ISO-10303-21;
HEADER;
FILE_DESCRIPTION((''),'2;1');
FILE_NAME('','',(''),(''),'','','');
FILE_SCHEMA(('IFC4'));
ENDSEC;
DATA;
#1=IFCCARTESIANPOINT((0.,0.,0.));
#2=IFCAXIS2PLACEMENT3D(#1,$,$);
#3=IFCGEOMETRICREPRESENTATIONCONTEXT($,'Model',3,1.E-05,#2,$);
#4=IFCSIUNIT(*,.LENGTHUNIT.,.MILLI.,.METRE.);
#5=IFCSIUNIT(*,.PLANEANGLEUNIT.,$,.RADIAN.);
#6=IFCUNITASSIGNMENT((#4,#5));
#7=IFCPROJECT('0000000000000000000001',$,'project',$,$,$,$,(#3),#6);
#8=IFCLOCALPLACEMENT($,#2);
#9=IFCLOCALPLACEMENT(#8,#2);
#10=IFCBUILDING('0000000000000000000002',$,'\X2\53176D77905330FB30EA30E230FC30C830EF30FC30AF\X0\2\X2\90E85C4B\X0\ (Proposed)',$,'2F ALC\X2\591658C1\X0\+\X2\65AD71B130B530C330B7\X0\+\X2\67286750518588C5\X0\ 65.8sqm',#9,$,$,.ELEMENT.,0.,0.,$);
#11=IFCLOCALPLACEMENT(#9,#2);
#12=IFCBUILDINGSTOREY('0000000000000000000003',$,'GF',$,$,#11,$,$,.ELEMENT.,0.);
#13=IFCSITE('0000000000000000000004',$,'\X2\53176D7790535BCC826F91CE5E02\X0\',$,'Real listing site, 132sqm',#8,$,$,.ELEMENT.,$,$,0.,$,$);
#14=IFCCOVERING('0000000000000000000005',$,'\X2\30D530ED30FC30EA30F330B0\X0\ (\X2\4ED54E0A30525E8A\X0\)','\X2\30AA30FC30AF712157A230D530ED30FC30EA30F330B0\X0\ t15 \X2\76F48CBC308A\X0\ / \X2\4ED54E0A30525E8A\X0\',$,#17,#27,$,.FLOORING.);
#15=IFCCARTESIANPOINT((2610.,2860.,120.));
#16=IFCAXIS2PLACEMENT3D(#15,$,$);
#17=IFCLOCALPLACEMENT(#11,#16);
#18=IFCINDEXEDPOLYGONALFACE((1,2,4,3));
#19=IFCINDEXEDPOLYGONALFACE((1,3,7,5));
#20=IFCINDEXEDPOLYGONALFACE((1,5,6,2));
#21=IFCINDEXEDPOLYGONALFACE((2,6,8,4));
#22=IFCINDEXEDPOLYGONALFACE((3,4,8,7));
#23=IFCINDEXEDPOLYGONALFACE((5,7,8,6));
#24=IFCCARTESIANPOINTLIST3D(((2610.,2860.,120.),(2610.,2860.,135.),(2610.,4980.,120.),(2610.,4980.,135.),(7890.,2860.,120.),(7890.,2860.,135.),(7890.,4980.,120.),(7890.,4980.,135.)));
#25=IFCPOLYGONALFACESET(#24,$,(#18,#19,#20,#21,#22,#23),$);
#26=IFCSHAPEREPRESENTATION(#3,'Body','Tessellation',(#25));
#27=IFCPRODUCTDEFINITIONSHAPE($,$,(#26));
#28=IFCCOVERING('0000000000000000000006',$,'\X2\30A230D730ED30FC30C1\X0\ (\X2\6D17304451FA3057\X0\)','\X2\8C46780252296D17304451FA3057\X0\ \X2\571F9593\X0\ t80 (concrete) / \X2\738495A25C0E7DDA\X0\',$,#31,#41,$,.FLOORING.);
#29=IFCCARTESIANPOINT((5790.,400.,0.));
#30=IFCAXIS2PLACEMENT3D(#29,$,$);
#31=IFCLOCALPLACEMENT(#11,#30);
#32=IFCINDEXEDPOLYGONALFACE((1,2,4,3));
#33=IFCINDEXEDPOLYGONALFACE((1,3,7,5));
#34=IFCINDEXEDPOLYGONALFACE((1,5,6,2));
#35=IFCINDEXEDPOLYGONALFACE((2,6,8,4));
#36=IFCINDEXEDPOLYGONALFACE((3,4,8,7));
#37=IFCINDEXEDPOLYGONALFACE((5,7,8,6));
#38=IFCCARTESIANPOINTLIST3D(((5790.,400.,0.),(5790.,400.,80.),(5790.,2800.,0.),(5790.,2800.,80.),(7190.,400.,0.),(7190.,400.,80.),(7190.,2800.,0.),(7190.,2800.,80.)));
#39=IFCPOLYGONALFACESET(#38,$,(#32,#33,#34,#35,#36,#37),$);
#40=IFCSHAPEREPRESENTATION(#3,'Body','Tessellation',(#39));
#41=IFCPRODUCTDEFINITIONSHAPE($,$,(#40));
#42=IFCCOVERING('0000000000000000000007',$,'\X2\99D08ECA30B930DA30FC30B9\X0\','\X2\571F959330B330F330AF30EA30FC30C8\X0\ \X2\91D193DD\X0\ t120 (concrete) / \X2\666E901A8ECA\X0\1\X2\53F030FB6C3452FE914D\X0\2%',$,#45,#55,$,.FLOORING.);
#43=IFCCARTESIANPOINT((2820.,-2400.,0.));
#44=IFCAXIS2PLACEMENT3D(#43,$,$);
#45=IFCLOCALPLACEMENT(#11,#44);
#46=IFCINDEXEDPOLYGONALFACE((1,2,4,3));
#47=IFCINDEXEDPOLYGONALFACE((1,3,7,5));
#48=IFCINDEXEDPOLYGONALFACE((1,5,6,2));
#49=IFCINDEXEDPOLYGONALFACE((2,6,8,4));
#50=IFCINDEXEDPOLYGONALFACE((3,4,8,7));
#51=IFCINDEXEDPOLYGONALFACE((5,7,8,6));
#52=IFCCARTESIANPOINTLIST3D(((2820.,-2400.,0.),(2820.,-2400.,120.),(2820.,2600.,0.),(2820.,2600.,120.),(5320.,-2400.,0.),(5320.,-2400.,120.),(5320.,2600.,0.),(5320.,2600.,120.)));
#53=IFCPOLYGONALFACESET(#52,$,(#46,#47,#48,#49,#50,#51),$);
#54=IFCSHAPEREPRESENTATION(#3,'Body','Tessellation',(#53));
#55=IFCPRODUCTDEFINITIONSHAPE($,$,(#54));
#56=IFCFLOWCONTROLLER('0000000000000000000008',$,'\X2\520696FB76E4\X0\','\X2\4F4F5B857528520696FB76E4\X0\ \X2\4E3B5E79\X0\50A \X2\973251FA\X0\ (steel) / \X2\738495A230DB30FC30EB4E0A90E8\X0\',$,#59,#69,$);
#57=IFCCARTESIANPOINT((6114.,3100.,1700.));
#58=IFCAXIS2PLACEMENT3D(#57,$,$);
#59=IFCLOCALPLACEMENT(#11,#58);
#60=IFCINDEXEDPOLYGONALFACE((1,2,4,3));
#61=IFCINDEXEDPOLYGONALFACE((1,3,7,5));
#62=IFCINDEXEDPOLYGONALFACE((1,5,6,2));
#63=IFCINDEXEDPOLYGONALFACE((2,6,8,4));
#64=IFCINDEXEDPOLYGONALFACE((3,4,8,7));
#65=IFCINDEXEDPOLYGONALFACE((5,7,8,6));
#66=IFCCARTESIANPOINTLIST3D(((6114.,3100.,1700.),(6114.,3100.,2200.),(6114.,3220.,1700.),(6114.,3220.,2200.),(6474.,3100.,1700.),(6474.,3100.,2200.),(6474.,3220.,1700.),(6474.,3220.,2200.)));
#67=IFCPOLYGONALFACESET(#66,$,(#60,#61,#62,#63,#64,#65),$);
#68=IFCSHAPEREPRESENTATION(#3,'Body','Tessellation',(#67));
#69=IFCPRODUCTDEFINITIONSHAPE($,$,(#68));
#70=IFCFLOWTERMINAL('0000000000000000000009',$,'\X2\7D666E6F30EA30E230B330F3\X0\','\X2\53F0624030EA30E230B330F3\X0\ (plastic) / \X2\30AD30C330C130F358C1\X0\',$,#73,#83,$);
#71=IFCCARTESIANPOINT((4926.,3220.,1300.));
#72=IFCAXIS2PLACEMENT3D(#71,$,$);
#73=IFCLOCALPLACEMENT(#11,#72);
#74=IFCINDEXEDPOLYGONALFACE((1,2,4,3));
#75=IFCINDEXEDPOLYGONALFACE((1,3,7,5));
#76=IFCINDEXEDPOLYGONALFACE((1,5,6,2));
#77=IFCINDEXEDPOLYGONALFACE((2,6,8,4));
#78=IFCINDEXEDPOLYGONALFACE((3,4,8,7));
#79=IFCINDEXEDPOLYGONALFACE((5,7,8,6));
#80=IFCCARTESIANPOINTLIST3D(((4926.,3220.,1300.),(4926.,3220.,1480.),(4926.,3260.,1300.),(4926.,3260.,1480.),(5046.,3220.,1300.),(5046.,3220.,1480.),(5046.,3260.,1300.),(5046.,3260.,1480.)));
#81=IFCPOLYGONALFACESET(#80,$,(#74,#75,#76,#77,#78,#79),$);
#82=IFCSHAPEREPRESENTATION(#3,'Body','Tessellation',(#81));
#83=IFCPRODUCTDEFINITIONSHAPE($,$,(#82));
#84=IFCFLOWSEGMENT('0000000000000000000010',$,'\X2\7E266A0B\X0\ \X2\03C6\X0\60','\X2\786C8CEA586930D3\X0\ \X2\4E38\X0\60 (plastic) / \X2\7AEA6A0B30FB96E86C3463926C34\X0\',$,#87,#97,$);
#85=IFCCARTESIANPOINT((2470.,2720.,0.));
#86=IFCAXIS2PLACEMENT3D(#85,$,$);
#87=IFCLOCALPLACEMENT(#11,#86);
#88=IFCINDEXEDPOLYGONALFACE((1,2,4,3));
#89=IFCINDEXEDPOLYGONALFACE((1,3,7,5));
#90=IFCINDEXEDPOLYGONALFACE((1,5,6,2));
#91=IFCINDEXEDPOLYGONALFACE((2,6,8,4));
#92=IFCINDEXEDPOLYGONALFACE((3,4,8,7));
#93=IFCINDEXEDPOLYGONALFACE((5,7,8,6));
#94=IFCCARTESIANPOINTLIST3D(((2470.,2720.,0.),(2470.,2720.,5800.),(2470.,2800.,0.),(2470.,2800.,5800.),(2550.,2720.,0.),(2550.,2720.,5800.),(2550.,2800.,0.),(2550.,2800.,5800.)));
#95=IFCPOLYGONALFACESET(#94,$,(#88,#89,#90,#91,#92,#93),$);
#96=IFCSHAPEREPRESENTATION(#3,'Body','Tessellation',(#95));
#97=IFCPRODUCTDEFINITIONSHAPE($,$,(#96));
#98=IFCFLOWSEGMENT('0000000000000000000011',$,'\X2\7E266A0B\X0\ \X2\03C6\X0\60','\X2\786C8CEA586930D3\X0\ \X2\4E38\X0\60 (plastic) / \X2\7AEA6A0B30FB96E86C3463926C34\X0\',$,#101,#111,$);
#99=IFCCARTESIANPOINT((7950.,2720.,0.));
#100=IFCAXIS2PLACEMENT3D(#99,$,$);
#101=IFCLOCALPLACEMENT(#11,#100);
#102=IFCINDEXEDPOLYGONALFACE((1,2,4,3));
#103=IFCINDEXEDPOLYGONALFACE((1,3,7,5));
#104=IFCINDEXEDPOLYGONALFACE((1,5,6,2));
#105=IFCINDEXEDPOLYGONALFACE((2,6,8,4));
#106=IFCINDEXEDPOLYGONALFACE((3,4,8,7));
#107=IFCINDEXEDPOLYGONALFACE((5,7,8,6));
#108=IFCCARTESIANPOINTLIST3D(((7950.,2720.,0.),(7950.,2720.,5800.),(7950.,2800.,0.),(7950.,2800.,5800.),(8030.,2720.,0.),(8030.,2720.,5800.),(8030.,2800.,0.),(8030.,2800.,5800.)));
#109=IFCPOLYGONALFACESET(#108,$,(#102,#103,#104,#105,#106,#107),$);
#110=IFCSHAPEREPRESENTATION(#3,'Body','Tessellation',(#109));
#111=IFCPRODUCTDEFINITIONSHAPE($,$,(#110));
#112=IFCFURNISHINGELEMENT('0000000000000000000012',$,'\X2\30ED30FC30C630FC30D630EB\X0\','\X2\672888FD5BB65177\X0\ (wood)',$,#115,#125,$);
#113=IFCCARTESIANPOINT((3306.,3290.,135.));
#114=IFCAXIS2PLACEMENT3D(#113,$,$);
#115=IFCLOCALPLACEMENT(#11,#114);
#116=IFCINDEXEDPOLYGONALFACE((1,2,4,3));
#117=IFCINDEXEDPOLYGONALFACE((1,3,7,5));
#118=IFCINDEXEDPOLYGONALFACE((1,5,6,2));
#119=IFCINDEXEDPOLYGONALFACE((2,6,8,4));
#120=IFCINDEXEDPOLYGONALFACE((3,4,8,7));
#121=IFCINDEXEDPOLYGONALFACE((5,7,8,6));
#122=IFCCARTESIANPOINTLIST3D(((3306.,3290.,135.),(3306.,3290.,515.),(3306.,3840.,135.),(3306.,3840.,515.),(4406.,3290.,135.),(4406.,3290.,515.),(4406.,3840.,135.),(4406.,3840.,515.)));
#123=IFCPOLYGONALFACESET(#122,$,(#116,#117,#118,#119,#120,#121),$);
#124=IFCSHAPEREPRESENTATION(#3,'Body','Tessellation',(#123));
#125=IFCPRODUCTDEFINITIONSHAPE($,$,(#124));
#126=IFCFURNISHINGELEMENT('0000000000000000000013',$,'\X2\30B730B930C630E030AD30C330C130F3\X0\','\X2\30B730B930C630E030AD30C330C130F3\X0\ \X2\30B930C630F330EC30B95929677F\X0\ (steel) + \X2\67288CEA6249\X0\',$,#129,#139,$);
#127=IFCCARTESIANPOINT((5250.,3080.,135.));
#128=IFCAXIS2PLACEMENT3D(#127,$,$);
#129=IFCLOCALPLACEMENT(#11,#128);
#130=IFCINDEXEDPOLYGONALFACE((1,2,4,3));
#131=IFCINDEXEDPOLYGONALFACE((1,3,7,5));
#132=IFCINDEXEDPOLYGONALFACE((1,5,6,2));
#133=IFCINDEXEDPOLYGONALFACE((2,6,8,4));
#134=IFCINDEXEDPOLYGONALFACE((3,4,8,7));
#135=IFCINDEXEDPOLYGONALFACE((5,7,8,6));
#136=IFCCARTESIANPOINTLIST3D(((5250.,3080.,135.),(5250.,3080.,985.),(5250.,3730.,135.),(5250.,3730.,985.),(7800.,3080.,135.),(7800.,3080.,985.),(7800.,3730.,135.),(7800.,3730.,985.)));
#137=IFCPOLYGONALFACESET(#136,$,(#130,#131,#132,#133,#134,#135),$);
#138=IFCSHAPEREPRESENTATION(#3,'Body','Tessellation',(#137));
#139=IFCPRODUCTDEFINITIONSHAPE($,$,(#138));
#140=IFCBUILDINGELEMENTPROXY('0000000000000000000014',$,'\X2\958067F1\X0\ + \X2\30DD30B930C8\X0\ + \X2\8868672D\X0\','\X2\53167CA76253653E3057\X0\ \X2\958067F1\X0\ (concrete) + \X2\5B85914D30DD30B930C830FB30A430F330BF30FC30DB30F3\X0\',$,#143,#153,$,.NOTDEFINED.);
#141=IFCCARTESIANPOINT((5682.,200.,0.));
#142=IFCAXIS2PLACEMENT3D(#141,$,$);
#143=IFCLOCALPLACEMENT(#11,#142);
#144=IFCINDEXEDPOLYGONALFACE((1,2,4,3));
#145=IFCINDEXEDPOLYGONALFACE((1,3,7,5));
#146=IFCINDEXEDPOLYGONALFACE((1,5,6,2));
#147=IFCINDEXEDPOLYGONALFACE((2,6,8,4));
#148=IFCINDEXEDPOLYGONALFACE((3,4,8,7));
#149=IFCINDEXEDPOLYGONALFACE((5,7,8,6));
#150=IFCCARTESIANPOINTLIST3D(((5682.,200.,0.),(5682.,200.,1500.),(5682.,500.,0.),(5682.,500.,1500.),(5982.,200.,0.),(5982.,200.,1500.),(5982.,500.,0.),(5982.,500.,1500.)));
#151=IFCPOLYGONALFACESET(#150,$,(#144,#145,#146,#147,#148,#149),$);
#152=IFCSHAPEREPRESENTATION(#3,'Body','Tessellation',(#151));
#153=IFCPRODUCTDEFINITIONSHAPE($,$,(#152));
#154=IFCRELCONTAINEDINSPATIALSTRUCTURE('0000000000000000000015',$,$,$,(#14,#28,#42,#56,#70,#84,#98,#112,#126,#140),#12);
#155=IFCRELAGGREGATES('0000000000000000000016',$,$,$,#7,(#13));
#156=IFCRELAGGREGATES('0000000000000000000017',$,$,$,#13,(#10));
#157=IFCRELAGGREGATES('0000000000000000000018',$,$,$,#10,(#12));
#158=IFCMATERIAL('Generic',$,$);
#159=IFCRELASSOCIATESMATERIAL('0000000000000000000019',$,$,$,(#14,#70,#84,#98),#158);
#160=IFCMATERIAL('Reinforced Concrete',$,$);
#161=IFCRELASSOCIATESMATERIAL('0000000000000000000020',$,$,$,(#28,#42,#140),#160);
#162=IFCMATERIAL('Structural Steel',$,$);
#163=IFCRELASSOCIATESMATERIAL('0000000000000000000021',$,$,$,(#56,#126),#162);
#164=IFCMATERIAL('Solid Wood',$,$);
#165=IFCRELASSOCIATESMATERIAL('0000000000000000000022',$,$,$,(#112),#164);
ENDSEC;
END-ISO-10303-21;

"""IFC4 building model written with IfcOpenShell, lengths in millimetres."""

from ifc_helpers import new_model, si_unit, frame, frame_2d, origin, place, context, project, spatial, rectangle, extrude, material, element, save


model = new_model("IFC4")

# Units and contexts
model_context = context("Model", 3, precision=1e-05, world=origin())
ifc_project = project(units=[si_unit("LENGTHUNIT", "METRE", prefix="MILLI"), si_unit("PLANEANGLEUNIT", "RADIAN")], contexts=[model_context])

# Site, building, storey
site_placement = place(None, origin())
site = spatial("IfcSite", under=ifc_project, at=site_placement, Name="北海道富良野市", ObjectType="Real listing site, 132sqm", CompositionType="ELEMENT", RefElevation=0.0)
building_placement = place(site_placement, origin())
building = spatial("IfcBuilding", under=site, at=building_placement, Name="北海道・リモートワーク2部屋 (Proposed)", ObjectType="2F ALC外壁+断熱サッシ+木材内装 65.8sqm", CompositionType="ELEMENT", ElevationOfRefHeight=0.0, ElevationOfTerrain=0.0)
storey_placement = place(building_placement, origin())
storey = spatial("IfcBuildingStorey", under=building, at=storey_placement, Name="GF", CompositionType="ELEMENT", Elevation=0.0)

# Shared definitions
ifc_material_1 = material(Name="Solid Wood")

# Shared definitions
ifc_material_2 = material(Name="Reinforced Concrete")

# Coverings
ifc_material_3 = material(Name="Generic")
covering_1_placement = place(storey_placement, frame((2610.0, 2860.0, 120.0)))
element("IfcCovering", 1, at=covering_1_placement, inside=storey, material=ifc_material_3, Name="フローリング (仕上げ床)", Description="オーク無垢フローリング t15 直貼り / 仕上げ床", PredefinedType="FLOORING", context=model_context, shape_type="SweptSolid", body=[
    extrude(rectangle(XDim=5280.0, YDim=2120.0, at=frame_2d((2640.0, 1060.0))), frame((2610.0, 2860.0, 120.0)), (0.0, 0.0, 1.0), 15.0),
])
covering_2_placement = place(storey_placement, frame((5790.0, 400.0, 0.0)))
element("IfcCovering", 2, at=covering_2_placement, inside=storey, material=ifc_material_2, Name="アプローチ (洗い出し)", Description="豆砂利洗い出し 土間 t80 (concrete) / 玄関導線", PredefinedType="FLOORING", context=model_context, shape_type="SweptSolid", body=[
    extrude(rectangle(XDim=1400.0, YDim=2400.0, at=frame_2d((700.0, 1200.0))), frame((5790.0, 400.0, 0.0)), (0.0, 0.0, 1.0), 80.0),
])
covering_3_placement = place(storey_placement, frame((2820.0, -2400.0, 0.0)))
element("IfcCovering", 3, at=covering_3_placement, inside=storey, material=ifc_material_2, Name="駐車スペース", Description="土間コンクリート 金鏝 t120 (concrete) / 普通車1台・水勾配2%", PredefinedType="FLOORING", context=model_context, shape_type="SweptSolid", body=[
    extrude(rectangle(XDim=2500.0, YDim=5000.0, at=frame_2d((1250.0, 2500.0))), frame((2820.0, -2400.0, 0.0)), (0.0, 0.0, 1.0), 120.0),
])

# Flow controller
ifc_material_4 = material(Name="Structural Steel")
flow_controller_placement = place(storey_placement, frame((6114.0, 3100.0, 1700.0)))
element("IfcFlowController", 4, at=flow_controller_placement, inside=storey, material=ifc_material_4, Name="分電盤", Description="住宅用分電盤 主幹50A 露出 (steel) / 玄関ホール上部", context=model_context, shape_type="SweptSolid", body=[
    extrude(rectangle(XDim=360.0, YDim=120.0, at=frame_2d((180.0, 60.0))), frame((6114.0, 3100.0, 1700.0)), (0.0, 0.0, 1.0), 500.0),
])

# Flow terminal
flow_terminal_placement = place(storey_placement, frame((4926.0, 3220.0, 1300.0)))
element("IfcFlowTerminal", 5, at=flow_terminal_placement, inside=storey, material=ifc_material_3, Name="給湯リモコン", Description="台所リモコン (plastic) / キッチン壁", context=model_context, shape_type="SweptSolid", body=[
    extrude(rectangle(XDim=120.0, YDim=40.0, at=frame_2d((60.0, 20.0))), frame((4926.0, 3220.0, 1300.0)), (0.0, 0.0, 1.0), 180.0),
])

# Flow segments
flow_segment_1_placement = place(storey_placement, frame((2470.0, 2720.0, 0.0)))
element("IfcFlowSegment", 6, at=flow_segment_1_placement, inside=storey, material=ifc_material_3, Name="縦樋 φ60", Description="硬質塩ビ 丸60 (plastic) / 竪樋・雨水排水", context=model_context, shape_type="SweptSolid", body=[
    extrude(rectangle(XDim=80.0, YDim=80.0, at=frame_2d((40.0, 40.0))), frame((2470.0, 2720.0, 0.0)), (0.0, 0.0, 1.0), 5800.0),
])
flow_segment_2_placement = place(storey_placement, frame((7950.0, 2720.0, 0.0)))
element("IfcFlowSegment", 7, at=flow_segment_2_placement, inside=storey, material=ifc_material_3, Name="縦樋 φ60", Description="硬質塩ビ 丸60 (plastic) / 竪樋・雨水排水", context=model_context, shape_type="SweptSolid", body=[
    extrude(rectangle(XDim=80.0, YDim=80.0, at=frame_2d((40.0, 40.0))), frame((7950.0, 2720.0, 0.0)), (0.0, 0.0, 1.0), 5800.0),
])

# Furnishing elements
furnishing_1_placement = place(storey_placement, frame((3306.0, 3290.0, 135.0)))
element("IfcFurnishingElement", 8, at=furnishing_1_placement, inside=storey, material=ifc_material_1, Name="ローテーブル", Description="木製家具 (wood)", context=model_context, shape_type="SweptSolid", body=[
    extrude(rectangle(XDim=1100.0, YDim=550.0, at=frame_2d((550.0, 275.0))), frame((3306.0, 3290.0, 135.0)), (0.0, 0.0, 1.0), 380.0),
])
furnishing_2_placement = place(storey_placement, frame((5250.0, 3080.0, 135.0)))
element("IfcFurnishingElement", 9, at=furnishing_2_placement, inside=storey, material=ifc_material_4, Name="システムキッチン", Description="システムキッチン ステンレス天板 (steel) + 木質扉", context=model_context, shape_type="SweptSolid", body=[
    extrude(rectangle(XDim=2550.0, YDim=650.0, at=frame_2d((1275.0, 325.0))), frame((5250.0, 3080.0, 135.0)), (0.0, 0.0, 1.0), 850.0),
])

# Building element proxy
proxy_placement = place(storey_placement, frame((5682.0, 200.0, 0.0)))
element("IfcBuildingElementProxy", 10, at=proxy_placement, inside=storey, material=ifc_material_2, Name="門柱 + ポスト + 表札", Description="化粧打放し 門柱 (concrete) + 宅配ポスト・インターホン", PredefinedType="NOTDEFINED", context=model_context, shape_type="SweptSolid", body=[
    extrude(rectangle(XDim=300.0, YDim=300.0, at=frame_2d((150.0, 150.0))), frame((5682.0, 200.0, 0.0)), (0.0, 0.0, 1.0), 1500.0),
])

save(model, "model.ifc")
